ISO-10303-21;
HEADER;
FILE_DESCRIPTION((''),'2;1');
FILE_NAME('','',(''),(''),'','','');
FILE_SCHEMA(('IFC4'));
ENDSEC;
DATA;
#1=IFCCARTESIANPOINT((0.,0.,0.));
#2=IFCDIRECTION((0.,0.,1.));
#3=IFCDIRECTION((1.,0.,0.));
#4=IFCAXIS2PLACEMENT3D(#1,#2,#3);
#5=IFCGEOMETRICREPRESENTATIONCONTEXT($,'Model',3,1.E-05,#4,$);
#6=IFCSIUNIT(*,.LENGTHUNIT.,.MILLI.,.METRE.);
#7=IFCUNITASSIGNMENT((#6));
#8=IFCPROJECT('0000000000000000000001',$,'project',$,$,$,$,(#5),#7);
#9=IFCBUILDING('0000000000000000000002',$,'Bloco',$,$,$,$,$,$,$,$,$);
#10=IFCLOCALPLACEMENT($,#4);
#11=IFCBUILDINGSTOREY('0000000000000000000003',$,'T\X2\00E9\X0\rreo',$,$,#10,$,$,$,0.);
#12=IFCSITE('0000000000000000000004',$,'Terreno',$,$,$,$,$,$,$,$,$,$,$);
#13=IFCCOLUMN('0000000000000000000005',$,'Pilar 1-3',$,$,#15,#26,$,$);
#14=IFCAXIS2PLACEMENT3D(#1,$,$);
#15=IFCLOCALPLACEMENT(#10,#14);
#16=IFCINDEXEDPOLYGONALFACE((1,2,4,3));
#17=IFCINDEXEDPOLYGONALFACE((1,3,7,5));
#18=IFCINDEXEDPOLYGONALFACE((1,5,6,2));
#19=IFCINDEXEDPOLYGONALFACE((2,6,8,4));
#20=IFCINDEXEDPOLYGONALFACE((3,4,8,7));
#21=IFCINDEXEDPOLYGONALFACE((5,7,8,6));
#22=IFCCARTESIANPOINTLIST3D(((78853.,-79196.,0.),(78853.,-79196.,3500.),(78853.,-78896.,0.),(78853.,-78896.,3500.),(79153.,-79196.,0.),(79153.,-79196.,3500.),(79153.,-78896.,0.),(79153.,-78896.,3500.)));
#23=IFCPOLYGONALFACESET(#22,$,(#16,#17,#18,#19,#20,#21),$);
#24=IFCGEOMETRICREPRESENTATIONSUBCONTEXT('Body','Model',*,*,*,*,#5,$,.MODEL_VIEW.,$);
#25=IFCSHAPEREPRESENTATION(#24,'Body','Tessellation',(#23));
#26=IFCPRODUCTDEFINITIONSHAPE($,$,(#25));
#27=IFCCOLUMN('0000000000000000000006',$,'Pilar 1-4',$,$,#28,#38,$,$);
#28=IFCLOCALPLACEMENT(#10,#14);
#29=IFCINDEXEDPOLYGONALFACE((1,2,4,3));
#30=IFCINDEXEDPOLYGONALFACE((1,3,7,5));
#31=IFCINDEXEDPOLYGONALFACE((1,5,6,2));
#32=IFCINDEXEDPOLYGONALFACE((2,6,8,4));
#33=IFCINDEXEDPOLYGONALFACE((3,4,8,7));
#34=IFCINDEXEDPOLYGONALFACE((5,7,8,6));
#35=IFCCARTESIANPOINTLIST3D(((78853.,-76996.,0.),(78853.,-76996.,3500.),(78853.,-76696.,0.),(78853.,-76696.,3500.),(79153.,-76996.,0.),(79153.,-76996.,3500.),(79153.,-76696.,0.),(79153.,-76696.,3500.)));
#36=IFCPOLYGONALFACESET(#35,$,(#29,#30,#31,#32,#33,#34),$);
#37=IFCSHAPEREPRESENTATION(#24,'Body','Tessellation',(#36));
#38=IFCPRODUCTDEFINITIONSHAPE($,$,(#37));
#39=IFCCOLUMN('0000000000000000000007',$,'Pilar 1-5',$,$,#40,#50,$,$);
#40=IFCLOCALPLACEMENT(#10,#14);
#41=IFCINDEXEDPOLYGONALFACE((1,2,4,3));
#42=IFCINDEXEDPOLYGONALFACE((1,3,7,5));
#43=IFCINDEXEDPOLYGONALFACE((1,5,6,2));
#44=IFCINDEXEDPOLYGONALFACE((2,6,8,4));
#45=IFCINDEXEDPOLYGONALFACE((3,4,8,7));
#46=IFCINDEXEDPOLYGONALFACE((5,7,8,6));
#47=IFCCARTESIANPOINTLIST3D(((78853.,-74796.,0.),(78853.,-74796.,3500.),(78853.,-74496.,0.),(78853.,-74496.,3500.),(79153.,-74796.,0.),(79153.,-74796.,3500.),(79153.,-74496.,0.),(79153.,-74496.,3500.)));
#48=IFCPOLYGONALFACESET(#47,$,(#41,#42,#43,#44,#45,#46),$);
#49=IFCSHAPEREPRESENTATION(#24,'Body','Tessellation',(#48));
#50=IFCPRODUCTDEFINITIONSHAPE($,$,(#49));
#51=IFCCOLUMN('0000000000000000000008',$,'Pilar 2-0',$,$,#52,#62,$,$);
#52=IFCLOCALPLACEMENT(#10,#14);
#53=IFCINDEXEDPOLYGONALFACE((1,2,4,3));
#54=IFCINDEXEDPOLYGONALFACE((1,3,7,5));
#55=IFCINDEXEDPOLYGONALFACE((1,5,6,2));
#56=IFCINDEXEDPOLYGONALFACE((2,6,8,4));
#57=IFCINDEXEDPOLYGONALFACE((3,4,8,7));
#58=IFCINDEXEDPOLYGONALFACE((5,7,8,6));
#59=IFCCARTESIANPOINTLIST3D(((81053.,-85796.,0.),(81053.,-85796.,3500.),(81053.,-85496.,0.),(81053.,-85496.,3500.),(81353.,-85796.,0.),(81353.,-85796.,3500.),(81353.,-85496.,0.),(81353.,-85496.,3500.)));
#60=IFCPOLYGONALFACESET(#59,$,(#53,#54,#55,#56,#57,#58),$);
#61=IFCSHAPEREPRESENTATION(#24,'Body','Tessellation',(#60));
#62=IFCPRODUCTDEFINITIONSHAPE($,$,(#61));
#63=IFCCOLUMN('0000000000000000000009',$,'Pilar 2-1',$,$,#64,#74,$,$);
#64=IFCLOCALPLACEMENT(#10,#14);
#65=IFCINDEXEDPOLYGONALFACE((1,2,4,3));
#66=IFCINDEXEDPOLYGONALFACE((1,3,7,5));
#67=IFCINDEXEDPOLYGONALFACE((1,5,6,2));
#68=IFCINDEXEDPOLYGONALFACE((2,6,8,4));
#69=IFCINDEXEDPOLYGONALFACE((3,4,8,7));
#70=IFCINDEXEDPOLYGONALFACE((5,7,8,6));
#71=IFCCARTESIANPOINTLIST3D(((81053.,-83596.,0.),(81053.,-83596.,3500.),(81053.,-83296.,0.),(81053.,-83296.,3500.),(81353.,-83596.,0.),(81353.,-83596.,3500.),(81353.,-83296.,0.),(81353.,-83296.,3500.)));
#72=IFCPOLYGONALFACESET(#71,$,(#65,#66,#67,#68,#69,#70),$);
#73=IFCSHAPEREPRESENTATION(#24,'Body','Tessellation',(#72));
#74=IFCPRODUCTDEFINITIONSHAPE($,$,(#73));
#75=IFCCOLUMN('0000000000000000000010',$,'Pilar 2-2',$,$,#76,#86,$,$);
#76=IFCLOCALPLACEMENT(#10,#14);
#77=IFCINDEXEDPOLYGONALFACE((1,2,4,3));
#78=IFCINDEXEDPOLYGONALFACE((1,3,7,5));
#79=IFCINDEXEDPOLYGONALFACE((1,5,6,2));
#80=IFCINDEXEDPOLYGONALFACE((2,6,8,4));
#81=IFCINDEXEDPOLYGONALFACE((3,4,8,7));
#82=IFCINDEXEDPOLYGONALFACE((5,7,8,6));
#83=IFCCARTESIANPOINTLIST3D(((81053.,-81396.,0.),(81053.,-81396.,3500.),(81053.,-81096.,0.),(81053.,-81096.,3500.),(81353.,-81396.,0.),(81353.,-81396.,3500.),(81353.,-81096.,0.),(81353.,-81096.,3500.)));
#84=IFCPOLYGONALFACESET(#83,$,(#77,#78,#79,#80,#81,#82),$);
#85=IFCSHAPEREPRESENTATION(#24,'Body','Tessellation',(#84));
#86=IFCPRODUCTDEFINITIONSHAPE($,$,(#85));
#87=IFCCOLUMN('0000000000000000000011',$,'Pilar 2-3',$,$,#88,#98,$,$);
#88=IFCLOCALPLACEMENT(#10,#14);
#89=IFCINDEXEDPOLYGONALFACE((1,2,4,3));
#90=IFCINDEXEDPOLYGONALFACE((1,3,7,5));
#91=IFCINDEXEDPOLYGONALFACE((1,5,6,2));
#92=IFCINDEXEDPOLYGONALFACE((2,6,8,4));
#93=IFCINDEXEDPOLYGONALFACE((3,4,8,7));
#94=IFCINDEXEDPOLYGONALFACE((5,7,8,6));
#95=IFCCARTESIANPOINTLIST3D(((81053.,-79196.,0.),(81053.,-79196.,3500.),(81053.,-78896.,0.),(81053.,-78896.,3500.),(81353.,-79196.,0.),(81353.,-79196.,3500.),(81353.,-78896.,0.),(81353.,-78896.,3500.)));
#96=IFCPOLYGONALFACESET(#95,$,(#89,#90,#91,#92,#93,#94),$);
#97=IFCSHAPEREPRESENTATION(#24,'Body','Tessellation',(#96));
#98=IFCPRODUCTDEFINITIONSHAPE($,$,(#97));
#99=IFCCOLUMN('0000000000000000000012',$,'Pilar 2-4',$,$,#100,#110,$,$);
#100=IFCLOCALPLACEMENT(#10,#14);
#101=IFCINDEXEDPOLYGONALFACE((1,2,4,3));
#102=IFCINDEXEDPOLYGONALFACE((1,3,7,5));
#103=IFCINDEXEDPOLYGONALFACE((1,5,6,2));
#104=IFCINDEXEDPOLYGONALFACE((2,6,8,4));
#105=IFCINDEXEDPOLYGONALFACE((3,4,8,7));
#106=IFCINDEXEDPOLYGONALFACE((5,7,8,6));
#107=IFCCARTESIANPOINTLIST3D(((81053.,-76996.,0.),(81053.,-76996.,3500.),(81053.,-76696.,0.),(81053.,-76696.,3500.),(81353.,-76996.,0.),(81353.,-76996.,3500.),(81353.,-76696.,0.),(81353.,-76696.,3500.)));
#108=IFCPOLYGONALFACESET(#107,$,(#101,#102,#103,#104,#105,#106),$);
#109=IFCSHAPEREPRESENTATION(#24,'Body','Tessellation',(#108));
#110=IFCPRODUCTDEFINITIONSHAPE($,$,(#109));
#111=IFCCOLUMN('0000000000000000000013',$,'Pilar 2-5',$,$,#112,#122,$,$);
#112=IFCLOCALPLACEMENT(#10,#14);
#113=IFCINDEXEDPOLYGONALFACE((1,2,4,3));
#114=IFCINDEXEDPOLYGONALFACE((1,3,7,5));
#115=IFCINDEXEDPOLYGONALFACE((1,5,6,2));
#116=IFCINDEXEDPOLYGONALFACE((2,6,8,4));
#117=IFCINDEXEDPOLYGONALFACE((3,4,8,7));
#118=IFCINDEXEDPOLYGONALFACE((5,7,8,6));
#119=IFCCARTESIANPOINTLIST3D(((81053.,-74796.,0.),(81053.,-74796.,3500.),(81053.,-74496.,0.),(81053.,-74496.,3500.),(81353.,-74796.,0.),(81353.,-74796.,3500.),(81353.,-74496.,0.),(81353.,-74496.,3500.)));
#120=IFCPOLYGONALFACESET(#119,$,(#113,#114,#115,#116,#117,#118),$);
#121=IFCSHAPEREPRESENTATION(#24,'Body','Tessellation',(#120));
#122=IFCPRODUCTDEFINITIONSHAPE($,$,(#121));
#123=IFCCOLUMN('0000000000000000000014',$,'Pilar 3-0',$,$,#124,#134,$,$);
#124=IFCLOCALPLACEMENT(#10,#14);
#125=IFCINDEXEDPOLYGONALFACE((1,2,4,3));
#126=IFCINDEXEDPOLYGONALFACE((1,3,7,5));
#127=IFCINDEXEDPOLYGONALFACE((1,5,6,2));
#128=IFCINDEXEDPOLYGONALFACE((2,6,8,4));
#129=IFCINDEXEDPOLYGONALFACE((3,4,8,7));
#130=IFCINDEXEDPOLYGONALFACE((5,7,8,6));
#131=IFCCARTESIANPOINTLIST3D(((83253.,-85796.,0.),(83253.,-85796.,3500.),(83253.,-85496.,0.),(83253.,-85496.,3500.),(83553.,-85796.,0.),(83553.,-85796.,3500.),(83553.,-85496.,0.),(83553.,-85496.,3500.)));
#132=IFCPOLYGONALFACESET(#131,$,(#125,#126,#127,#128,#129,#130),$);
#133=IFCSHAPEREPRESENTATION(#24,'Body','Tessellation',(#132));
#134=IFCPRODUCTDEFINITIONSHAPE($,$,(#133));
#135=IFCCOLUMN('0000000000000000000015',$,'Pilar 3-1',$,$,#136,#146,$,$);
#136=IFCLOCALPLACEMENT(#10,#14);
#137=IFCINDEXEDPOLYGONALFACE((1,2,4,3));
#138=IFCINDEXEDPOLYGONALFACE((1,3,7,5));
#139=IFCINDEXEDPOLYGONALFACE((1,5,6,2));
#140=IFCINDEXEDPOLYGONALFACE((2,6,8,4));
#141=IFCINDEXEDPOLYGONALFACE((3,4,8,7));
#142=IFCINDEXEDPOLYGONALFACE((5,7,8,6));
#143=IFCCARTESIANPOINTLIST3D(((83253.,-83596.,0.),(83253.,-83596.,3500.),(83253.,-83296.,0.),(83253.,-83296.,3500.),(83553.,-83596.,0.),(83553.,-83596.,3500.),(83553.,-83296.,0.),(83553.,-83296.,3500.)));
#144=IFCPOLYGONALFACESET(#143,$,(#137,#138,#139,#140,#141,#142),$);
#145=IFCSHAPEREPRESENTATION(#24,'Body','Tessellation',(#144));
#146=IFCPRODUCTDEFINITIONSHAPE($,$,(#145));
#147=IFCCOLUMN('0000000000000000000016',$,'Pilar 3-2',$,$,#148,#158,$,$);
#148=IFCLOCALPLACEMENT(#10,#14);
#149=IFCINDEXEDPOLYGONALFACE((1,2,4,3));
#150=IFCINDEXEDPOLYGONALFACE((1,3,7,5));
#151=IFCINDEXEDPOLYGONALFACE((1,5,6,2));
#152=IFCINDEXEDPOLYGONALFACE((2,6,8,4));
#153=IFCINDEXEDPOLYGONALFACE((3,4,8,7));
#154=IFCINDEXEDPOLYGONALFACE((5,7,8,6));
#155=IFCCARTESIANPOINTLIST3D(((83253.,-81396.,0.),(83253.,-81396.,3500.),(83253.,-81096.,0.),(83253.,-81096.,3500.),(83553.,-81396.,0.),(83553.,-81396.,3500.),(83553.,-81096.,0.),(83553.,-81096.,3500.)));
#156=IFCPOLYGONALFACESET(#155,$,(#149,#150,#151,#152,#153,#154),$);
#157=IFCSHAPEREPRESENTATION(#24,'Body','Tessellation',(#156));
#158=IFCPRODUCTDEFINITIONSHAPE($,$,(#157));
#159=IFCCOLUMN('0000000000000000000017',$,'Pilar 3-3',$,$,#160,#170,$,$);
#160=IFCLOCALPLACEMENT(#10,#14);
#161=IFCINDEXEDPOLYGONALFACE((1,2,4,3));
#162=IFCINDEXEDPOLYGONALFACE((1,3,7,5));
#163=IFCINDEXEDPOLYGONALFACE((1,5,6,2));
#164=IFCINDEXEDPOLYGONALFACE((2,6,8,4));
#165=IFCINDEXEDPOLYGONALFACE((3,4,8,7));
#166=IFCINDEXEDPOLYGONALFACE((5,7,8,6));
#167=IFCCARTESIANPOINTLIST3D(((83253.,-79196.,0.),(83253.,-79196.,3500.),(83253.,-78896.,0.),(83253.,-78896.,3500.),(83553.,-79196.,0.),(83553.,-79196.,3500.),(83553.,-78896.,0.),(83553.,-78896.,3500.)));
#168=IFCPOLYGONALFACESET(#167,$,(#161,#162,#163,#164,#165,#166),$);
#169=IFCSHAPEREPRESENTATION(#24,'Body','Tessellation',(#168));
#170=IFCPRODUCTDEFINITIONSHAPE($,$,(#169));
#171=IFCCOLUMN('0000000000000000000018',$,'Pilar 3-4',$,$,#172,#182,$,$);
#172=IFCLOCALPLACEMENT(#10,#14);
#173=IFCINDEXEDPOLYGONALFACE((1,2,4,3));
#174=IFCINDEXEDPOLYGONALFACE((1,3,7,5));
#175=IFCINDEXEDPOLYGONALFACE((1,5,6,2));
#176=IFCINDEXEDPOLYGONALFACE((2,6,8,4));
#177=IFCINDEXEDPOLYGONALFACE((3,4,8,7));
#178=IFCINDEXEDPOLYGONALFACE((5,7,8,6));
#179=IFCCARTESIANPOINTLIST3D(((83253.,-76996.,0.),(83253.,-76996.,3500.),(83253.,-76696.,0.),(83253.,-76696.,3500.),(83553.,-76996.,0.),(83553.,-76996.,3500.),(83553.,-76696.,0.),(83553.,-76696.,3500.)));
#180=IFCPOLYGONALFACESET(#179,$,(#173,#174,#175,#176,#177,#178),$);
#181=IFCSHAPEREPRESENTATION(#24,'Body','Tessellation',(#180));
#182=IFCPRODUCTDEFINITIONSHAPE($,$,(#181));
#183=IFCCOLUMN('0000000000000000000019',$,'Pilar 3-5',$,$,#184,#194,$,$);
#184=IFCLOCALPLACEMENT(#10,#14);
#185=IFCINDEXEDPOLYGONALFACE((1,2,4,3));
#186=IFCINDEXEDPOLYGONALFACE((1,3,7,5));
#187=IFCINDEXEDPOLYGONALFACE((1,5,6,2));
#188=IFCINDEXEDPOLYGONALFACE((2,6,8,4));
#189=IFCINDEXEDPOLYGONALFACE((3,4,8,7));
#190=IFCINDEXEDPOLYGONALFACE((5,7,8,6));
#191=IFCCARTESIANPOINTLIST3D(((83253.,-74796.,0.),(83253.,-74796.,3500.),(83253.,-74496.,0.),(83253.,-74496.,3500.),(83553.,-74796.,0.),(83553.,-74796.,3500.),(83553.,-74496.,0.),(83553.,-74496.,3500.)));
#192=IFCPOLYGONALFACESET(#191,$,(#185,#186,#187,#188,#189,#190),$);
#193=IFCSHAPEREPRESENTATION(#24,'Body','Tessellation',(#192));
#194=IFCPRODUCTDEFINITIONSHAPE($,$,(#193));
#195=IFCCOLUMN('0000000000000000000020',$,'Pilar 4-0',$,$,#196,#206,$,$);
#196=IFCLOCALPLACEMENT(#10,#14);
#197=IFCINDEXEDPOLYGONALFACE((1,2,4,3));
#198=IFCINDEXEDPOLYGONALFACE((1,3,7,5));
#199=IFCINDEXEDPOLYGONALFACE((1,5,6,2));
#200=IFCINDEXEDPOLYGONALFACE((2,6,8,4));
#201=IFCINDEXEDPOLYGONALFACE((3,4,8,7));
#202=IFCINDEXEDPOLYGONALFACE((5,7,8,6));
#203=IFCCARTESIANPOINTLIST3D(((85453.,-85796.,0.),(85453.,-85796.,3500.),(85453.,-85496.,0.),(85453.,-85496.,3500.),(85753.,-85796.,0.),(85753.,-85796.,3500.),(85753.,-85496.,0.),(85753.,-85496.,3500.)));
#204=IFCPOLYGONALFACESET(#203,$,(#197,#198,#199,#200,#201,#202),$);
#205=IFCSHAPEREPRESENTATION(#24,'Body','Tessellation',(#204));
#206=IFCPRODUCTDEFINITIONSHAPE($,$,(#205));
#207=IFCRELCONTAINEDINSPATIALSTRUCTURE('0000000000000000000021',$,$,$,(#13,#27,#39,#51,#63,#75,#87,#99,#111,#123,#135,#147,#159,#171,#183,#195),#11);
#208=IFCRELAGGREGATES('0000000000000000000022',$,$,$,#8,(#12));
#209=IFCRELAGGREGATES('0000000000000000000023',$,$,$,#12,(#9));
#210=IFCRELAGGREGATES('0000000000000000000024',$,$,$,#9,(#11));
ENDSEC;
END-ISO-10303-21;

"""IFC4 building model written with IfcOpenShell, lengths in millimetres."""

from ifc_helpers import new_model, si_unit, origin, origin_with_axes, place, context, subcontext, project, spatial, polyline, outline, extrude, element, save


model = new_model("IFC4")

# Units and contexts
model_context = context("Model", 3, precision=1e-05, world=origin_with_axes())
body_context = subcontext(model_context, "Body", "Model", "MODEL_VIEW")
ifc_project = project(units=[si_unit("LENGTHUNIT", "METRE", prefix="MILLI")], contexts=[model_context])

# Site, building, storey
site = spatial("IfcSite", under=ifc_project, Name="Terreno")
building = spatial("IfcBuilding", under=site, Name="Bloco")
storey_placement = place(None, origin_with_axes())
storey = spatial("IfcBuildingStorey", under=building, at=storey_placement, Name="Térreo", Elevation=0.0)

# Columns
column_1_placement = place(storey_placement, origin_with_axes())
element("IfcColumn", 1, at=column_1_placement, inside=storey, Name="Pilar 1-3", context=body_context, shape_type="SweptSolid", body=[
    extrude(outline(polyline([(78853.0, -79196.0), (79153.0, -79196.0), (79153.0, -78896.0), (78853.0, -78896.0), (78853.0, -79196.0)])), origin(), (0.0, 0.0, 1.0), 3500.0),
])
column_2_placement = place(storey_placement, origin_with_axes())
element("IfcColumn", 2, at=column_2_placement, inside=storey, Name="Pilar 1-4", context=body_context, shape_type="SweptSolid", body=[
    extrude(outline(polyline([(78853.0, -76996.0), (79153.0, -76996.0), (79153.0, -76696.0), (78853.0, -76696.0), (78853.0, -76996.0)])), origin(), (0.0, 0.0, 1.0), 3500.0),
])
column_3_placement = place(storey_placement, origin_with_axes())
element("IfcColumn", 3, at=column_3_placement, inside=storey, Name="Pilar 1-5", context=body_context, shape_type="SweptSolid", body=[
    extrude(outline(polyline([(78853.0, -74796.0), (79153.0, -74796.0), (79153.0, -74496.0), (78853.0, -74496.0), (78853.0, -74796.0)])), origin(), (0.0, 0.0, 1.0), 3500.0),
])
column_4_placement = place(storey_placement, origin_with_axes())
element("IfcColumn", 4, at=column_4_placement, inside=storey, Name="Pilar 2-0", context=body_context, shape_type="SweptSolid", body=[
    extrude(outline(polyline([(81053.0, -85796.0), (81353.0, -85796.0), (81353.0, -85496.0), (81053.0, -85496.0), (81053.0, -85796.0)])), origin(), (0.0, 0.0, 1.0), 3500.0),
])
column_5_placement = place(storey_placement, origin_with_axes())
element("IfcColumn", 5, at=column_5_placement, inside=storey, Name="Pilar 2-1", context=body_context, shape_type="SweptSolid", body=[
    extrude(outline(polyline([(81053.0, -83596.0), (81353.0, -83596.0), (81353.0, -83296.0), (81053.0, -83296.0), (81053.0, -83596.0)])), origin(), (0.0, 0.0, 1.0), 3500.0),
])
column_6_placement = place(storey_placement, origin_with_axes())
element("IfcColumn", 6, at=column_6_placement, inside=storey, Name="Pilar 2-2", context=body_context, shape_type="SweptSolid", body=[
    extrude(outline(polyline([(81053.0, -81396.0), (81353.0, -81396.0), (81353.0, -81096.0), (81053.0, -81096.0), (81053.0, -81396.0)])), origin(), (0.0, 0.0, 1.0), 3500.0),
])
column_7_placement = place(storey_placement, origin_with_axes())
element("IfcColumn", 7, at=column_7_placement, inside=storey, Name="Pilar 2-3", context=body_context, shape_type="SweptSolid", body=[
    extrude(outline(polyline([(81053.0, -79196.0), (81353.0, -79196.0), (81353.0, -78896.0), (81053.0, -78896.0), (81053.0, -79196.0)])), origin(), (0.0, 0.0, 1.0), 3500.0),
])
column_8_placement = place(storey_placement, origin_with_axes())
element("IfcColumn", 8, at=column_8_placement, inside=storey, Name="Pilar 2-4", context=body_context, shape_type="SweptSolid", body=[
    extrude(outline(polyline([(81053.0, -76996.0), (81353.0, -76996.0), (81353.0, -76696.0), (81053.0, -76696.0), (81053.0, -76996.0)])), origin(), (0.0, 0.0, 1.0), 3500.0),
])
column_9_placement = place(storey_placement, origin_with_axes())
element("IfcColumn", 9, at=column_9_placement, inside=storey, Name="Pilar 2-5", context=body_context, shape_type="SweptSolid", body=[
    extrude(outline(polyline([(81053.0, -74796.0), (81353.0, -74796.0), (81353.0, -74496.0), (81053.0, -74496.0), (81053.0, -74796.0)])), origin(), (0.0, 0.0, 1.0), 3500.0),
])
column_10_placement = place(storey_placement, origin_with_axes())
element("IfcColumn", 10, at=column_10_placement, inside=storey, Name="Pilar 3-0", context=body_context, shape_type="SweptSolid", body=[
    extrude(outline(polyline([(83253.0, -85796.0), (83553.0, -85796.0), (83553.0, -85496.0), (83253.0, -85496.0), (83253.0, -85796.0)])), origin(), (0.0, 0.0, 1.0), 3500.0),
])
column_11_placement = place(storey_placement, origin_with_axes())
element("IfcColumn", 11, at=column_11_placement, inside=storey, Name="Pilar 3-1", context=body_context, shape_type="SweptSolid", body=[
    extrude(outline(polyline([(83253.0, -83596.0), (83553.0, -83596.0), (83553.0, -83296.0), (83253.0, -83296.0), (83253.0, -83596.0)])), origin(), (0.0, 0.0, 1.0), 3500.0),
])
column_12_placement = place(storey_placement, origin_with_axes())
element("IfcColumn", 12, at=column_12_placement, inside=storey, Name="Pilar 3-2", context=body_context, shape_type="SweptSolid", body=[
    extrude(outline(polyline([(83253.0, -81396.0), (83553.0, -81396.0), (83553.0, -81096.0), (83253.0, -81096.0), (83253.0, -81396.0)])), origin(), (0.0, 0.0, 1.0), 3500.0),
])
column_13_placement = place(storey_placement, origin_with_axes())
element("IfcColumn", 13, at=column_13_placement, inside=storey, Name="Pilar 3-3", context=body_context, shape_type="SweptSolid", body=[
    extrude(outline(polyline([(83253.0, -79196.0), (83553.0, -79196.0), (83553.0, -78896.0), (83253.0, -78896.0), (83253.0, -79196.0)])), origin(), (0.0, 0.0, 1.0), 3500.0),
])
column_14_placement = place(storey_placement, origin_with_axes())
element("IfcColumn", 14, at=column_14_placement, inside=storey, Name="Pilar 3-4", context=body_context, shape_type="SweptSolid", body=[
    extrude(outline(polyline([(83253.0, -76996.0), (83553.0, -76996.0), (83553.0, -76696.0), (83253.0, -76696.0), (83253.0, -76996.0)])), origin(), (0.0, 0.0, 1.0), 3500.0),
])
column_15_placement = place(storey_placement, origin_with_axes())
element("IfcColumn", 15, at=column_15_placement, inside=storey, Name="Pilar 3-5", context=body_context, shape_type="SweptSolid", body=[
    extrude(outline(polyline([(83253.0, -74796.0), (83553.0, -74796.0), (83553.0, -74496.0), (83253.0, -74496.0), (83253.0, -74796.0)])), origin(), (0.0, 0.0, 1.0), 3500.0),
])
column_16_placement = place(storey_placement, origin_with_axes())
element("IfcColumn", 16, at=column_16_placement, inside=storey, Name="Pilar 4-0", context=body_context, shape_type="SweptSolid", body=[
    extrude(outline(polyline([(85453.0, -85796.0), (85753.0, -85796.0), (85753.0, -85496.0), (85453.0, -85496.0), (85453.0, -85796.0)])), origin(), (0.0, 0.0, 1.0), 3500.0),
])

save(model, "model.ifc")
